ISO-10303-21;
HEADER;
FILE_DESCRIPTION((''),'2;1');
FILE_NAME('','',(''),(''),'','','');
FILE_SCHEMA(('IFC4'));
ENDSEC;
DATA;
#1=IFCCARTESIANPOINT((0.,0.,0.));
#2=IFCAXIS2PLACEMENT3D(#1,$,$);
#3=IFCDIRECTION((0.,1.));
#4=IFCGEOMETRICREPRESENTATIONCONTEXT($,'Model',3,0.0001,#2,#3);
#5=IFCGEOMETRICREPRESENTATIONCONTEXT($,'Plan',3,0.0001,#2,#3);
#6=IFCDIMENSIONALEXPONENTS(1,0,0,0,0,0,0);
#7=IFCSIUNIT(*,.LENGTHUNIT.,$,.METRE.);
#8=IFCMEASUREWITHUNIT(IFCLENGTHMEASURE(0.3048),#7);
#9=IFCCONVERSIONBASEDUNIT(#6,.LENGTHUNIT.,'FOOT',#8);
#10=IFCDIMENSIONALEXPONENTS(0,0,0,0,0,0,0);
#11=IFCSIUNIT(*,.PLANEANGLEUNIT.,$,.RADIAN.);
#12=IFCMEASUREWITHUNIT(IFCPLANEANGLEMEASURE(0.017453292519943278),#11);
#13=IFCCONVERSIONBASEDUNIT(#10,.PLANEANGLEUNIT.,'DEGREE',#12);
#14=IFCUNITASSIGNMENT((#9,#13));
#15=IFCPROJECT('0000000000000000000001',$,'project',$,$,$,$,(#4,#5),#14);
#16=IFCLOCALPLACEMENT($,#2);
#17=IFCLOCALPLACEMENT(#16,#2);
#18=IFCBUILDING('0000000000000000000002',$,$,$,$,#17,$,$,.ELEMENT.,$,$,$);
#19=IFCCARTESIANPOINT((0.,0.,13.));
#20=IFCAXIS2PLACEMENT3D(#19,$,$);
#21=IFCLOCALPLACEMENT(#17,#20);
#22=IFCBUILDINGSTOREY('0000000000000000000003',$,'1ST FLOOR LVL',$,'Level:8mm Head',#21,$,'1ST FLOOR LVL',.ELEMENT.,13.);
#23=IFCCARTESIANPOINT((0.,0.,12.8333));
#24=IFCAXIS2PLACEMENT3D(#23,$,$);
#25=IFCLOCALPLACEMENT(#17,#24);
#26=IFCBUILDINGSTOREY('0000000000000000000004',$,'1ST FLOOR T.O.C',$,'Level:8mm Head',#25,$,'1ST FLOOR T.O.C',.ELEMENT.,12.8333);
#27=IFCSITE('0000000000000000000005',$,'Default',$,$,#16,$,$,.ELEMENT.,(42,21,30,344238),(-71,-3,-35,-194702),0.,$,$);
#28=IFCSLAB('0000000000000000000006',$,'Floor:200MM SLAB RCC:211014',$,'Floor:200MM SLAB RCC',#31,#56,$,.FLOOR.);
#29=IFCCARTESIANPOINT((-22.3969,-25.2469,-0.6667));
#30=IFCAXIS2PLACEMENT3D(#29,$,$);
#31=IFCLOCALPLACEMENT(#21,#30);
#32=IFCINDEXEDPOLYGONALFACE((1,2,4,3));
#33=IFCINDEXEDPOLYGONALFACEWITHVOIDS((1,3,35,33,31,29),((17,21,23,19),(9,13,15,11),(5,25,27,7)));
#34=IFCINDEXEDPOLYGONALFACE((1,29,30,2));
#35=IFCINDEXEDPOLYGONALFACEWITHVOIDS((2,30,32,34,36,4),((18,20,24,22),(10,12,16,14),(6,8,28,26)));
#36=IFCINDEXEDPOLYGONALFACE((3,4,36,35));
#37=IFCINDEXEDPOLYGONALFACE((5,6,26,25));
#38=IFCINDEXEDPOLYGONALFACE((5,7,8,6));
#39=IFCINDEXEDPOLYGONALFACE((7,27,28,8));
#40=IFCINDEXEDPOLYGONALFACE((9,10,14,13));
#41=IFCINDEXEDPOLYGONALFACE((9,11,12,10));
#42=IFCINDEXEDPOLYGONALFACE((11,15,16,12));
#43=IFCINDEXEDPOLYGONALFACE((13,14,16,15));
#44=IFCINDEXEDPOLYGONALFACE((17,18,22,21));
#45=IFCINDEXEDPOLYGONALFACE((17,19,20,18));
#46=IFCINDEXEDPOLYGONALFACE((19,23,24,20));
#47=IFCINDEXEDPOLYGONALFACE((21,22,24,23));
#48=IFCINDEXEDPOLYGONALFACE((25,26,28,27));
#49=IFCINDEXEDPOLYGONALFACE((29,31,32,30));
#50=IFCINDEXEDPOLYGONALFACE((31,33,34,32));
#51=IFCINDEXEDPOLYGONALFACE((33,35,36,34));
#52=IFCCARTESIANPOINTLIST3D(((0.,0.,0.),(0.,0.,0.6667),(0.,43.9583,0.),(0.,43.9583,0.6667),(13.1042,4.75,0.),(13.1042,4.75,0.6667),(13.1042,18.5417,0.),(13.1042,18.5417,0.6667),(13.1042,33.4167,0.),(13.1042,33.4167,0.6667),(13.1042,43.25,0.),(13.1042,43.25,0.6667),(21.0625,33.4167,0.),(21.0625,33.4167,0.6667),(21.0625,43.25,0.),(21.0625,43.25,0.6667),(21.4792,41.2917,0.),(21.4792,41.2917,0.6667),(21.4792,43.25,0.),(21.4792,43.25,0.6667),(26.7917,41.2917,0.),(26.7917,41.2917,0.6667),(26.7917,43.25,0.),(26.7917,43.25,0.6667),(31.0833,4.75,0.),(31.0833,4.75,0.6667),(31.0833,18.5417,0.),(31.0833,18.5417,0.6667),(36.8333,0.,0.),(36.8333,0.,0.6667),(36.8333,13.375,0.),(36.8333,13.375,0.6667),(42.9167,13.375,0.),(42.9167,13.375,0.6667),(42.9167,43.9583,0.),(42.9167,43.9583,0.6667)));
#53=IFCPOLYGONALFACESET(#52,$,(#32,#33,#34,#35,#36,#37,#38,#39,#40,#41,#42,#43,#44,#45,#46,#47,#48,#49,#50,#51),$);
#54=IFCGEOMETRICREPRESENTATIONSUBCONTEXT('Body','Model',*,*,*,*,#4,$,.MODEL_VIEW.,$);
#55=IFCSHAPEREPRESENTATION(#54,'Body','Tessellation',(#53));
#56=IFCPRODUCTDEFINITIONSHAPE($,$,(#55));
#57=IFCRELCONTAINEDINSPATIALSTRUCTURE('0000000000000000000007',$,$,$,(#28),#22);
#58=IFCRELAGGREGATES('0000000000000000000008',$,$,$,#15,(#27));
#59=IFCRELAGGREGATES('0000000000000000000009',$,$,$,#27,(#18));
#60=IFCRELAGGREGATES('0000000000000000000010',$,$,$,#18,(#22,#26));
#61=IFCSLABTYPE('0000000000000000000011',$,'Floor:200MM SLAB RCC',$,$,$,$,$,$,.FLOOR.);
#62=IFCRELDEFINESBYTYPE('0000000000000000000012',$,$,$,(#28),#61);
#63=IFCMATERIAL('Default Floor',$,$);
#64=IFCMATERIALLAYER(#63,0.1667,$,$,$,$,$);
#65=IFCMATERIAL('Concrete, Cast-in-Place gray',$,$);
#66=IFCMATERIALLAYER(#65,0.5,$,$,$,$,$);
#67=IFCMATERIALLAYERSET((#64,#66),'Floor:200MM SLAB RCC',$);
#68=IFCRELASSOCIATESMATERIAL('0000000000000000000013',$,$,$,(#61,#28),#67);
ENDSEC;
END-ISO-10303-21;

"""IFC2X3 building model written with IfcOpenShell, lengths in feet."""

from ifc_helpers import new_model, entity, si_unit, converted_unit, direction, frame, frame_2d, origin, origin_2d_with_axis, place, context, subcontext, project, spatial, polyline, rectangle, outline, extrude, material, layer, layer_set, layer_usage, type_object, element, save


model = new_model("IFC2X3")

# Units and contexts
model_context = context("Model", 3, precision=0.0001, world=origin(), true_north=direction((0.0, 1.0)))
plan_context = context("Plan", 3, precision=0.0001, world=origin(), true_north=direction((0.0, 1.0)))
body_context = subcontext(model_context, "Body", "Model", "MODEL_VIEW")
ifc_project = project(units=[converted_unit("LENGTHUNIT", "FOOT", entity("IfcLengthMeasure", 0.3048), si_unit("LENGTHUNIT", "METRE"), dimensions=[1, 0, 0, 0, 0, 0, 0]), converted_unit("PLANEANGLEUNIT", "DEGREE", entity("IfcPlaneAngleMeasure", 0.017453292519943278), si_unit("PLANEANGLEUNIT", "RADIAN"), dimensions=[0, 0, 0, 0, 0, 0, 0])], contexts=[model_context, plan_context])

# Site, building, storey
site_placement = place(None, origin())
site = spatial("IfcSite", under=ifc_project, at=site_placement, Name="Default", CompositionType="ELEMENT", RefLatitude=(42, 21, 30, 344238), RefLongitude=(-71, -3, -35, -194702), RefElevation=0.0)
building_placement = place(site_placement, origin())
building = spatial("IfcBuilding", under=site, at=building_placement, CompositionType="ELEMENT")
storey_1_placement = place(building_placement, frame((0.0, 0.0, 13.0)))
storey_1 = spatial("IfcBuildingStorey", under=building, at=storey_1_placement, Name="1ST FLOOR LVL", ObjectType="Level:8mm Head", LongName="1ST FLOOR LVL", CompositionType="ELEMENT", Elevation=13.0)

# Slab, openings
ifc_material_1 = material(Name="Default Floor")
ifc_layer_1 = layer(ifc_material_1, 0.1667)
ifc_material_2 = material(Name="Concrete, Cast-in-Place gray")
ifc_layer_2 = layer(ifc_material_2, 0.5)
ifc_layer_set_1 = layer_set([ifc_layer_1, ifc_layer_2], Name="Floor:200MM SLAB RCC")
ifc_layer_usage_1 = layer_usage(ifc_layer_set_1, "AXIS3", "POSITIVE", 0.0)
slab_type = type_object("IfcSlabType", Name="Floor:200MM SLAB RCC", PredefinedType="FLOOR", material=ifc_layer_set_1)
slab_placement = place(storey_1_placement, frame((-22.3969, -25.2469, -0.6667)))
slab = element("IfcSlab", 1, at=slab_placement, inside=storey_1, type_object=slab_type, material=ifc_layer_usage_1, Name="Floor:200MM SLAB RCC:211014", ObjectType="Floor:200MM SLAB RCC", PredefinedType="FLOOR", context=body_context, shape_type="SweptSolid", body=[
    extrude(outline(polyline([(-21.4583, 21.9792), (-21.4583, -8.6042), (-15.375, -8.6042), (-15.375, -21.9792), (21.4583, -21.9792), (21.4583, 21.9792), (-21.4583, 21.9792)])), frame((21.4583, 21.9792, 0.6667), z_axis=(0.0, 0.0, -1.0), x_axis=(-1.0, 0.0, 0.0)), (0.0, 0.0, 1.0), 0.6667),
])
opening_1_placement = place(slab_placement, origin())
element("IfcOpeningElement", 2, at=opening_1_placement, cuts=slab, ObjectType="Opening", context=body_context, shape_type="SweptSolid", body=[
    extrude(rectangle(XDim=5.3125, YDim=1.9583, at=origin_2d_with_axis()), frame((24.1354, 42.2708, 0.0), z_axis=(0.0, 0.0, 1.0), x_axis=(-1.0, 0.0, 0.0)), (0.0, 0.0, 1.0), 0.6667),
])
opening_2_placement = place(slab_placement, origin())
element("IfcOpeningElement", 3, at=opening_2_placement, cuts=slab, ObjectType="Opening", context=body_context, shape_type="SweptSolid", body=[
    extrude(rectangle(XDim=9.8333, YDim=7.9583, at=frame_2d((0.0, 0.0), x_axis=(1.0, 0.0))), frame((17.0833, 38.3333, 0.6667), z_axis=(0.0, 0.0, -1.0), x_axis=(0.0, 1.0, 0.0)), (0.0, 0.0, 1.0), 0.6667),
])
opening_3_placement = place(slab_placement, origin())
element("IfcOpeningElement", 4, at=opening_3_placement, cuts=slab, ObjectType="Opening", context=body_context, shape_type="SweptSolid", body=[
    extrude(rectangle(XDim=13.7917, YDim=17.9792, at=origin_2d_with_axis()), frame((22.0937, 11.6458, 0.6667), z_axis=(0.0, 0.0, -1.0), x_axis=(0.0, -1.0, 0.0)), (0.0, 0.0, 1.0), 0.6667),
])

# Shared definitions
storey_2_placement = place(building_placement, frame((0.0, 0.0, 12.8333)))
storey_2 = spatial("IfcBuildingStorey", under=building, at=storey_2_placement, Name="1ST FLOOR T.O.C", ObjectType="Level:8mm Head", LongName="1ST FLOOR T.O.C", CompositionType="ELEMENT", Elevation=12.8333)

save(model, "model.ifc")
